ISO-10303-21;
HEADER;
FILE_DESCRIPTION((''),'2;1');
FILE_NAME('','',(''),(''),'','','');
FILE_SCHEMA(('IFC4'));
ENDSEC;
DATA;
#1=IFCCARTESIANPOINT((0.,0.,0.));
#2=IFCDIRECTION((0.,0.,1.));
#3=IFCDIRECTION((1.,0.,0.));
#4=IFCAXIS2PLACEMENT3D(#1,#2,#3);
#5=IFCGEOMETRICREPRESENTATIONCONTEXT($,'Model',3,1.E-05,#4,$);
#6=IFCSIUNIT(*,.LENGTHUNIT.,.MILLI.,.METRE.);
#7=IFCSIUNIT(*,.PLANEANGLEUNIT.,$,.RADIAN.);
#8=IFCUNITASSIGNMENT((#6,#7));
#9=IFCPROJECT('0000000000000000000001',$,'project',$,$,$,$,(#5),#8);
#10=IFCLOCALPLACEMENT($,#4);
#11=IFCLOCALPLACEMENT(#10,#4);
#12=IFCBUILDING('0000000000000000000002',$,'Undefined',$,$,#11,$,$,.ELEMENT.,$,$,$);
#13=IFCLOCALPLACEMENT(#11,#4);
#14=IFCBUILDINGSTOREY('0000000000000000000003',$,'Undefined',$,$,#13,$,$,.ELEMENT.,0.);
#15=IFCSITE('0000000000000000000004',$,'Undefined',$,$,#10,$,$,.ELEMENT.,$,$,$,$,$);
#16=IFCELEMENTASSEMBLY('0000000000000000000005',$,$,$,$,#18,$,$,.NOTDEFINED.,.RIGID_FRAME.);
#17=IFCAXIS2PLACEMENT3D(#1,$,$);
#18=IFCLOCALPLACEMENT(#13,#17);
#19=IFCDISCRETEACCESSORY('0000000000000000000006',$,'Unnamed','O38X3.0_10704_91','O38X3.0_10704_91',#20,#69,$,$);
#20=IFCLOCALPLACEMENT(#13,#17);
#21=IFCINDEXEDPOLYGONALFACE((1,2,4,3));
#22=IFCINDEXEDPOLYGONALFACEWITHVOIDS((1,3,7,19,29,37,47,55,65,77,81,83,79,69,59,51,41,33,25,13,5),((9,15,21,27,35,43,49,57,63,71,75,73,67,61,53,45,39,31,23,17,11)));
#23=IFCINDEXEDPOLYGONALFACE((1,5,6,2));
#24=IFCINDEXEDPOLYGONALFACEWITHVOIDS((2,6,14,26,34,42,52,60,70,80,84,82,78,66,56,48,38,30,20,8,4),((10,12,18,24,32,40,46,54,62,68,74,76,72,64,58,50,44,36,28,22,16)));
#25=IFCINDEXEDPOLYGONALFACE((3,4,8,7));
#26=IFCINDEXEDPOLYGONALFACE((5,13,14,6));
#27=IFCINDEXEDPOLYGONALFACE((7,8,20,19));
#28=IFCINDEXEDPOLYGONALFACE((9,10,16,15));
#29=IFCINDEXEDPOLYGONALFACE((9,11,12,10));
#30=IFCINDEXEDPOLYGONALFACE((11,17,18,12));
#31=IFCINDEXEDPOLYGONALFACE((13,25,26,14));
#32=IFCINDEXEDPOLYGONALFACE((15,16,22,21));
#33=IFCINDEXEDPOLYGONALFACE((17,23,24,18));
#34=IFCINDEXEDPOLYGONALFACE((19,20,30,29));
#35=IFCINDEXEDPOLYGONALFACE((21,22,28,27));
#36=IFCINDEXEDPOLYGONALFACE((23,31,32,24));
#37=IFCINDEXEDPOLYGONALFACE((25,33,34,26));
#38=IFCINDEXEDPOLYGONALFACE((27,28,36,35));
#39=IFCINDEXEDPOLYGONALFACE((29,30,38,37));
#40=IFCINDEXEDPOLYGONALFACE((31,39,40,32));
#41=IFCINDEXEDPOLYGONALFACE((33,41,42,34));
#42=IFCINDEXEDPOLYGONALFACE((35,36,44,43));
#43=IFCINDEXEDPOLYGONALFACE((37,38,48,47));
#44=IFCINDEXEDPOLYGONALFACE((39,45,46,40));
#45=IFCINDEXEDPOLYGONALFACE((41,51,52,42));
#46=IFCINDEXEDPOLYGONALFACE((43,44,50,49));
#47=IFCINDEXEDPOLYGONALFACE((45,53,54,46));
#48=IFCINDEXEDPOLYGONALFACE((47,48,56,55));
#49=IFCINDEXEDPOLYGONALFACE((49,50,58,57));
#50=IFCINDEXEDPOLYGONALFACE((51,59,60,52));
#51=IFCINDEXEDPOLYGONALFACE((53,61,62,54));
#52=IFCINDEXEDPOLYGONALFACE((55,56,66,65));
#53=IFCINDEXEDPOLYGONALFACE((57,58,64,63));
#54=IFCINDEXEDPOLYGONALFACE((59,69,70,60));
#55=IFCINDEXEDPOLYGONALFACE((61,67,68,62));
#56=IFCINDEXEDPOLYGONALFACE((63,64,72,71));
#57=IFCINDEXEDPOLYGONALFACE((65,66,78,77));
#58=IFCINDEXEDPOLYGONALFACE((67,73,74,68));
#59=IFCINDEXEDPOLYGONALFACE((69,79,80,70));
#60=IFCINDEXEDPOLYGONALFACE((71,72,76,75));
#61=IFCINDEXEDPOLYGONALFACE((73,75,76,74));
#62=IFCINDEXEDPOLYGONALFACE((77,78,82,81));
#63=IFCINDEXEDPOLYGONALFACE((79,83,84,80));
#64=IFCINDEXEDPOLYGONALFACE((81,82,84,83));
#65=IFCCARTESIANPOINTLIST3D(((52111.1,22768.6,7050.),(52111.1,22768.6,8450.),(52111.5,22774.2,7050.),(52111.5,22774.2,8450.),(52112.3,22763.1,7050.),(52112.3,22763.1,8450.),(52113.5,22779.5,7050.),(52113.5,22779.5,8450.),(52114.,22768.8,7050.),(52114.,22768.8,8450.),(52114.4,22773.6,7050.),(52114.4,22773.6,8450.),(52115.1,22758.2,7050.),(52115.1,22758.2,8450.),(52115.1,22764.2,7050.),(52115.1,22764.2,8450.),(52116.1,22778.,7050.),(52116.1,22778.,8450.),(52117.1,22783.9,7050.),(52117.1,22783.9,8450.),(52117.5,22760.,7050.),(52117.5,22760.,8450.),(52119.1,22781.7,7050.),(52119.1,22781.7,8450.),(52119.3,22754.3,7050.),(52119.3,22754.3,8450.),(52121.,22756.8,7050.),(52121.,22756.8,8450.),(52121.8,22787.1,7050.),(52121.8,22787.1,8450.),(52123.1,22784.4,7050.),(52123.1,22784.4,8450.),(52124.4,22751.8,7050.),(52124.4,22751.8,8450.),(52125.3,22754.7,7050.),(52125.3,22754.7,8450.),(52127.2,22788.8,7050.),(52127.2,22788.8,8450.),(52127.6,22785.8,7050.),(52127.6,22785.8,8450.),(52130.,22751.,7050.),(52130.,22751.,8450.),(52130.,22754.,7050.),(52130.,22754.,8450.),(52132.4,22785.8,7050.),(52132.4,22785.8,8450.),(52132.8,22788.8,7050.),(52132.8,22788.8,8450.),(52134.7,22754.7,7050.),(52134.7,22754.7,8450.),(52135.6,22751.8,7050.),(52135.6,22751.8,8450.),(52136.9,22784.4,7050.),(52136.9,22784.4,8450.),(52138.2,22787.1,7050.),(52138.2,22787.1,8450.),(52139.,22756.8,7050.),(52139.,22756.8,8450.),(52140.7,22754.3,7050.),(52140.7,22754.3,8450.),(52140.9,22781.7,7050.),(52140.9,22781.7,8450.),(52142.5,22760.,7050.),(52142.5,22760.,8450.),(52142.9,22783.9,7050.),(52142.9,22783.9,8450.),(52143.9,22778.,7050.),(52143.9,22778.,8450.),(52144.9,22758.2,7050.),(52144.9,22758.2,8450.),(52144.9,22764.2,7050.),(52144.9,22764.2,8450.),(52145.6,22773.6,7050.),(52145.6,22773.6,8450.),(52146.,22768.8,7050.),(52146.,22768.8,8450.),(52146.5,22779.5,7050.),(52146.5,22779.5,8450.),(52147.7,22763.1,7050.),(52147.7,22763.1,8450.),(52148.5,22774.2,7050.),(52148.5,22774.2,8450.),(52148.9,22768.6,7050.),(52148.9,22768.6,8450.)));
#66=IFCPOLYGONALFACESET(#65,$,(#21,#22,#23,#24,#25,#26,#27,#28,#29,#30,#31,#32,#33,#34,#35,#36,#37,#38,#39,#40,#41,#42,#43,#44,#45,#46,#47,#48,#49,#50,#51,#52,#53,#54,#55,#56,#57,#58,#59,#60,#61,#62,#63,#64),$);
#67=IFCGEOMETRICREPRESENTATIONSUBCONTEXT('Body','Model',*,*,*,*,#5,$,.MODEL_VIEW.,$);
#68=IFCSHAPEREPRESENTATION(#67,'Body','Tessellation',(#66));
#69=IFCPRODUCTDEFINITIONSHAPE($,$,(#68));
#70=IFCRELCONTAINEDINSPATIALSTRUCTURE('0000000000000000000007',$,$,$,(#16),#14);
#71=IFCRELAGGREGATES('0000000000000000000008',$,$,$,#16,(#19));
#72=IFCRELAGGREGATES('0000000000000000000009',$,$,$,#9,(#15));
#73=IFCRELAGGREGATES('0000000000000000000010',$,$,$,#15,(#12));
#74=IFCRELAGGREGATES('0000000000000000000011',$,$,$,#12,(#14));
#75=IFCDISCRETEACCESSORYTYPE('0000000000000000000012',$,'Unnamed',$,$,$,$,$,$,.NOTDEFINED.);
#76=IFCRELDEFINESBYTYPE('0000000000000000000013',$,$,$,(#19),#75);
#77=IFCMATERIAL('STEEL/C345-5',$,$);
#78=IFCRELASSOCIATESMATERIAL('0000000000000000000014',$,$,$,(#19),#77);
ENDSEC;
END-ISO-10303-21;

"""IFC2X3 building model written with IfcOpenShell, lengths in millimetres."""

from ifc_helpers import new_model, si_unit, frame, origin_with_axes, origin_2d_with_axis, place, context, subcontext, project, spatial, hollow_circle, extrude, material, type_object, element, aggregate, save


model = new_model("IFC2X3")

# Units and contexts
model_context = context("Model", 3, precision=1e-05, world=origin_with_axes())
body_context = subcontext(model_context, "Body", "Model", "MODEL_VIEW")
ifc_project = project(units=[si_unit("LENGTHUNIT", "METRE", prefix="MILLI"), si_unit("PLANEANGLEUNIT", "RADIAN")], contexts=[model_context])

# Site, building, storey
site_placement = place(None, origin_with_axes())
site = spatial("IfcSite", under=ifc_project, at=site_placement, Name="Undefined", CompositionType="ELEMENT")
building_placement = place(site_placement, origin_with_axes())
building = spatial("IfcBuilding", under=site, at=building_placement, Name="Undefined", CompositionType="ELEMENT")
storey_placement = place(building_placement, origin_with_axes())
storey = spatial("IfcBuildingStorey", under=building, at=storey_placement, Name="Undefined", CompositionType="ELEMENT", Elevation=0.0)

# Element assembly
assembly_1_placement = place(storey_placement, origin_with_axes())
assembly_1 = element("IfcElementAssembly", 1, at=assembly_1_placement, inside=storey, AssemblyPlace="NOTDEFINED", PredefinedType="RIGID_FRAME")
ifc_material_1 = material(Name="STEEL/C345-5")

# Discrete accessory
discrete_accessory_type = type_object("IfcDiscreteAccessoryType", Name="Unnamed")
discrete_accessory_placement = place(assembly_1_placement, frame((52130.0, 22770.0, 7050.0), z_axis=(0.0, 0.0, 1.0), x_axis=(-1.0, 0.0, 0.0)))
discrete_accessory = element("IfcDiscreteAccessory", 2, at=discrete_accessory_placement, type_object=discrete_accessory_type, material=ifc_material_1, Name="Unnamed", Description="O38X3.0_10704_91", ObjectType="O38X3.0_10704_91", context=body_context, shape_type="SweptSolid", body=[
    extrude(hollow_circle(Radius=19.0, WallThickness=3.0, at=origin_2d_with_axis()), frame((0.0, 0.0, 1400.0), z_axis=(0.0, 0.0, -1.0), x_axis=(0.0, 1.0, 0.0)), (0.0, 0.0, 1.0), 1400.0),
])
aggregate(assembly_1, [discrete_accessory])

save(model, "model.ifc")
